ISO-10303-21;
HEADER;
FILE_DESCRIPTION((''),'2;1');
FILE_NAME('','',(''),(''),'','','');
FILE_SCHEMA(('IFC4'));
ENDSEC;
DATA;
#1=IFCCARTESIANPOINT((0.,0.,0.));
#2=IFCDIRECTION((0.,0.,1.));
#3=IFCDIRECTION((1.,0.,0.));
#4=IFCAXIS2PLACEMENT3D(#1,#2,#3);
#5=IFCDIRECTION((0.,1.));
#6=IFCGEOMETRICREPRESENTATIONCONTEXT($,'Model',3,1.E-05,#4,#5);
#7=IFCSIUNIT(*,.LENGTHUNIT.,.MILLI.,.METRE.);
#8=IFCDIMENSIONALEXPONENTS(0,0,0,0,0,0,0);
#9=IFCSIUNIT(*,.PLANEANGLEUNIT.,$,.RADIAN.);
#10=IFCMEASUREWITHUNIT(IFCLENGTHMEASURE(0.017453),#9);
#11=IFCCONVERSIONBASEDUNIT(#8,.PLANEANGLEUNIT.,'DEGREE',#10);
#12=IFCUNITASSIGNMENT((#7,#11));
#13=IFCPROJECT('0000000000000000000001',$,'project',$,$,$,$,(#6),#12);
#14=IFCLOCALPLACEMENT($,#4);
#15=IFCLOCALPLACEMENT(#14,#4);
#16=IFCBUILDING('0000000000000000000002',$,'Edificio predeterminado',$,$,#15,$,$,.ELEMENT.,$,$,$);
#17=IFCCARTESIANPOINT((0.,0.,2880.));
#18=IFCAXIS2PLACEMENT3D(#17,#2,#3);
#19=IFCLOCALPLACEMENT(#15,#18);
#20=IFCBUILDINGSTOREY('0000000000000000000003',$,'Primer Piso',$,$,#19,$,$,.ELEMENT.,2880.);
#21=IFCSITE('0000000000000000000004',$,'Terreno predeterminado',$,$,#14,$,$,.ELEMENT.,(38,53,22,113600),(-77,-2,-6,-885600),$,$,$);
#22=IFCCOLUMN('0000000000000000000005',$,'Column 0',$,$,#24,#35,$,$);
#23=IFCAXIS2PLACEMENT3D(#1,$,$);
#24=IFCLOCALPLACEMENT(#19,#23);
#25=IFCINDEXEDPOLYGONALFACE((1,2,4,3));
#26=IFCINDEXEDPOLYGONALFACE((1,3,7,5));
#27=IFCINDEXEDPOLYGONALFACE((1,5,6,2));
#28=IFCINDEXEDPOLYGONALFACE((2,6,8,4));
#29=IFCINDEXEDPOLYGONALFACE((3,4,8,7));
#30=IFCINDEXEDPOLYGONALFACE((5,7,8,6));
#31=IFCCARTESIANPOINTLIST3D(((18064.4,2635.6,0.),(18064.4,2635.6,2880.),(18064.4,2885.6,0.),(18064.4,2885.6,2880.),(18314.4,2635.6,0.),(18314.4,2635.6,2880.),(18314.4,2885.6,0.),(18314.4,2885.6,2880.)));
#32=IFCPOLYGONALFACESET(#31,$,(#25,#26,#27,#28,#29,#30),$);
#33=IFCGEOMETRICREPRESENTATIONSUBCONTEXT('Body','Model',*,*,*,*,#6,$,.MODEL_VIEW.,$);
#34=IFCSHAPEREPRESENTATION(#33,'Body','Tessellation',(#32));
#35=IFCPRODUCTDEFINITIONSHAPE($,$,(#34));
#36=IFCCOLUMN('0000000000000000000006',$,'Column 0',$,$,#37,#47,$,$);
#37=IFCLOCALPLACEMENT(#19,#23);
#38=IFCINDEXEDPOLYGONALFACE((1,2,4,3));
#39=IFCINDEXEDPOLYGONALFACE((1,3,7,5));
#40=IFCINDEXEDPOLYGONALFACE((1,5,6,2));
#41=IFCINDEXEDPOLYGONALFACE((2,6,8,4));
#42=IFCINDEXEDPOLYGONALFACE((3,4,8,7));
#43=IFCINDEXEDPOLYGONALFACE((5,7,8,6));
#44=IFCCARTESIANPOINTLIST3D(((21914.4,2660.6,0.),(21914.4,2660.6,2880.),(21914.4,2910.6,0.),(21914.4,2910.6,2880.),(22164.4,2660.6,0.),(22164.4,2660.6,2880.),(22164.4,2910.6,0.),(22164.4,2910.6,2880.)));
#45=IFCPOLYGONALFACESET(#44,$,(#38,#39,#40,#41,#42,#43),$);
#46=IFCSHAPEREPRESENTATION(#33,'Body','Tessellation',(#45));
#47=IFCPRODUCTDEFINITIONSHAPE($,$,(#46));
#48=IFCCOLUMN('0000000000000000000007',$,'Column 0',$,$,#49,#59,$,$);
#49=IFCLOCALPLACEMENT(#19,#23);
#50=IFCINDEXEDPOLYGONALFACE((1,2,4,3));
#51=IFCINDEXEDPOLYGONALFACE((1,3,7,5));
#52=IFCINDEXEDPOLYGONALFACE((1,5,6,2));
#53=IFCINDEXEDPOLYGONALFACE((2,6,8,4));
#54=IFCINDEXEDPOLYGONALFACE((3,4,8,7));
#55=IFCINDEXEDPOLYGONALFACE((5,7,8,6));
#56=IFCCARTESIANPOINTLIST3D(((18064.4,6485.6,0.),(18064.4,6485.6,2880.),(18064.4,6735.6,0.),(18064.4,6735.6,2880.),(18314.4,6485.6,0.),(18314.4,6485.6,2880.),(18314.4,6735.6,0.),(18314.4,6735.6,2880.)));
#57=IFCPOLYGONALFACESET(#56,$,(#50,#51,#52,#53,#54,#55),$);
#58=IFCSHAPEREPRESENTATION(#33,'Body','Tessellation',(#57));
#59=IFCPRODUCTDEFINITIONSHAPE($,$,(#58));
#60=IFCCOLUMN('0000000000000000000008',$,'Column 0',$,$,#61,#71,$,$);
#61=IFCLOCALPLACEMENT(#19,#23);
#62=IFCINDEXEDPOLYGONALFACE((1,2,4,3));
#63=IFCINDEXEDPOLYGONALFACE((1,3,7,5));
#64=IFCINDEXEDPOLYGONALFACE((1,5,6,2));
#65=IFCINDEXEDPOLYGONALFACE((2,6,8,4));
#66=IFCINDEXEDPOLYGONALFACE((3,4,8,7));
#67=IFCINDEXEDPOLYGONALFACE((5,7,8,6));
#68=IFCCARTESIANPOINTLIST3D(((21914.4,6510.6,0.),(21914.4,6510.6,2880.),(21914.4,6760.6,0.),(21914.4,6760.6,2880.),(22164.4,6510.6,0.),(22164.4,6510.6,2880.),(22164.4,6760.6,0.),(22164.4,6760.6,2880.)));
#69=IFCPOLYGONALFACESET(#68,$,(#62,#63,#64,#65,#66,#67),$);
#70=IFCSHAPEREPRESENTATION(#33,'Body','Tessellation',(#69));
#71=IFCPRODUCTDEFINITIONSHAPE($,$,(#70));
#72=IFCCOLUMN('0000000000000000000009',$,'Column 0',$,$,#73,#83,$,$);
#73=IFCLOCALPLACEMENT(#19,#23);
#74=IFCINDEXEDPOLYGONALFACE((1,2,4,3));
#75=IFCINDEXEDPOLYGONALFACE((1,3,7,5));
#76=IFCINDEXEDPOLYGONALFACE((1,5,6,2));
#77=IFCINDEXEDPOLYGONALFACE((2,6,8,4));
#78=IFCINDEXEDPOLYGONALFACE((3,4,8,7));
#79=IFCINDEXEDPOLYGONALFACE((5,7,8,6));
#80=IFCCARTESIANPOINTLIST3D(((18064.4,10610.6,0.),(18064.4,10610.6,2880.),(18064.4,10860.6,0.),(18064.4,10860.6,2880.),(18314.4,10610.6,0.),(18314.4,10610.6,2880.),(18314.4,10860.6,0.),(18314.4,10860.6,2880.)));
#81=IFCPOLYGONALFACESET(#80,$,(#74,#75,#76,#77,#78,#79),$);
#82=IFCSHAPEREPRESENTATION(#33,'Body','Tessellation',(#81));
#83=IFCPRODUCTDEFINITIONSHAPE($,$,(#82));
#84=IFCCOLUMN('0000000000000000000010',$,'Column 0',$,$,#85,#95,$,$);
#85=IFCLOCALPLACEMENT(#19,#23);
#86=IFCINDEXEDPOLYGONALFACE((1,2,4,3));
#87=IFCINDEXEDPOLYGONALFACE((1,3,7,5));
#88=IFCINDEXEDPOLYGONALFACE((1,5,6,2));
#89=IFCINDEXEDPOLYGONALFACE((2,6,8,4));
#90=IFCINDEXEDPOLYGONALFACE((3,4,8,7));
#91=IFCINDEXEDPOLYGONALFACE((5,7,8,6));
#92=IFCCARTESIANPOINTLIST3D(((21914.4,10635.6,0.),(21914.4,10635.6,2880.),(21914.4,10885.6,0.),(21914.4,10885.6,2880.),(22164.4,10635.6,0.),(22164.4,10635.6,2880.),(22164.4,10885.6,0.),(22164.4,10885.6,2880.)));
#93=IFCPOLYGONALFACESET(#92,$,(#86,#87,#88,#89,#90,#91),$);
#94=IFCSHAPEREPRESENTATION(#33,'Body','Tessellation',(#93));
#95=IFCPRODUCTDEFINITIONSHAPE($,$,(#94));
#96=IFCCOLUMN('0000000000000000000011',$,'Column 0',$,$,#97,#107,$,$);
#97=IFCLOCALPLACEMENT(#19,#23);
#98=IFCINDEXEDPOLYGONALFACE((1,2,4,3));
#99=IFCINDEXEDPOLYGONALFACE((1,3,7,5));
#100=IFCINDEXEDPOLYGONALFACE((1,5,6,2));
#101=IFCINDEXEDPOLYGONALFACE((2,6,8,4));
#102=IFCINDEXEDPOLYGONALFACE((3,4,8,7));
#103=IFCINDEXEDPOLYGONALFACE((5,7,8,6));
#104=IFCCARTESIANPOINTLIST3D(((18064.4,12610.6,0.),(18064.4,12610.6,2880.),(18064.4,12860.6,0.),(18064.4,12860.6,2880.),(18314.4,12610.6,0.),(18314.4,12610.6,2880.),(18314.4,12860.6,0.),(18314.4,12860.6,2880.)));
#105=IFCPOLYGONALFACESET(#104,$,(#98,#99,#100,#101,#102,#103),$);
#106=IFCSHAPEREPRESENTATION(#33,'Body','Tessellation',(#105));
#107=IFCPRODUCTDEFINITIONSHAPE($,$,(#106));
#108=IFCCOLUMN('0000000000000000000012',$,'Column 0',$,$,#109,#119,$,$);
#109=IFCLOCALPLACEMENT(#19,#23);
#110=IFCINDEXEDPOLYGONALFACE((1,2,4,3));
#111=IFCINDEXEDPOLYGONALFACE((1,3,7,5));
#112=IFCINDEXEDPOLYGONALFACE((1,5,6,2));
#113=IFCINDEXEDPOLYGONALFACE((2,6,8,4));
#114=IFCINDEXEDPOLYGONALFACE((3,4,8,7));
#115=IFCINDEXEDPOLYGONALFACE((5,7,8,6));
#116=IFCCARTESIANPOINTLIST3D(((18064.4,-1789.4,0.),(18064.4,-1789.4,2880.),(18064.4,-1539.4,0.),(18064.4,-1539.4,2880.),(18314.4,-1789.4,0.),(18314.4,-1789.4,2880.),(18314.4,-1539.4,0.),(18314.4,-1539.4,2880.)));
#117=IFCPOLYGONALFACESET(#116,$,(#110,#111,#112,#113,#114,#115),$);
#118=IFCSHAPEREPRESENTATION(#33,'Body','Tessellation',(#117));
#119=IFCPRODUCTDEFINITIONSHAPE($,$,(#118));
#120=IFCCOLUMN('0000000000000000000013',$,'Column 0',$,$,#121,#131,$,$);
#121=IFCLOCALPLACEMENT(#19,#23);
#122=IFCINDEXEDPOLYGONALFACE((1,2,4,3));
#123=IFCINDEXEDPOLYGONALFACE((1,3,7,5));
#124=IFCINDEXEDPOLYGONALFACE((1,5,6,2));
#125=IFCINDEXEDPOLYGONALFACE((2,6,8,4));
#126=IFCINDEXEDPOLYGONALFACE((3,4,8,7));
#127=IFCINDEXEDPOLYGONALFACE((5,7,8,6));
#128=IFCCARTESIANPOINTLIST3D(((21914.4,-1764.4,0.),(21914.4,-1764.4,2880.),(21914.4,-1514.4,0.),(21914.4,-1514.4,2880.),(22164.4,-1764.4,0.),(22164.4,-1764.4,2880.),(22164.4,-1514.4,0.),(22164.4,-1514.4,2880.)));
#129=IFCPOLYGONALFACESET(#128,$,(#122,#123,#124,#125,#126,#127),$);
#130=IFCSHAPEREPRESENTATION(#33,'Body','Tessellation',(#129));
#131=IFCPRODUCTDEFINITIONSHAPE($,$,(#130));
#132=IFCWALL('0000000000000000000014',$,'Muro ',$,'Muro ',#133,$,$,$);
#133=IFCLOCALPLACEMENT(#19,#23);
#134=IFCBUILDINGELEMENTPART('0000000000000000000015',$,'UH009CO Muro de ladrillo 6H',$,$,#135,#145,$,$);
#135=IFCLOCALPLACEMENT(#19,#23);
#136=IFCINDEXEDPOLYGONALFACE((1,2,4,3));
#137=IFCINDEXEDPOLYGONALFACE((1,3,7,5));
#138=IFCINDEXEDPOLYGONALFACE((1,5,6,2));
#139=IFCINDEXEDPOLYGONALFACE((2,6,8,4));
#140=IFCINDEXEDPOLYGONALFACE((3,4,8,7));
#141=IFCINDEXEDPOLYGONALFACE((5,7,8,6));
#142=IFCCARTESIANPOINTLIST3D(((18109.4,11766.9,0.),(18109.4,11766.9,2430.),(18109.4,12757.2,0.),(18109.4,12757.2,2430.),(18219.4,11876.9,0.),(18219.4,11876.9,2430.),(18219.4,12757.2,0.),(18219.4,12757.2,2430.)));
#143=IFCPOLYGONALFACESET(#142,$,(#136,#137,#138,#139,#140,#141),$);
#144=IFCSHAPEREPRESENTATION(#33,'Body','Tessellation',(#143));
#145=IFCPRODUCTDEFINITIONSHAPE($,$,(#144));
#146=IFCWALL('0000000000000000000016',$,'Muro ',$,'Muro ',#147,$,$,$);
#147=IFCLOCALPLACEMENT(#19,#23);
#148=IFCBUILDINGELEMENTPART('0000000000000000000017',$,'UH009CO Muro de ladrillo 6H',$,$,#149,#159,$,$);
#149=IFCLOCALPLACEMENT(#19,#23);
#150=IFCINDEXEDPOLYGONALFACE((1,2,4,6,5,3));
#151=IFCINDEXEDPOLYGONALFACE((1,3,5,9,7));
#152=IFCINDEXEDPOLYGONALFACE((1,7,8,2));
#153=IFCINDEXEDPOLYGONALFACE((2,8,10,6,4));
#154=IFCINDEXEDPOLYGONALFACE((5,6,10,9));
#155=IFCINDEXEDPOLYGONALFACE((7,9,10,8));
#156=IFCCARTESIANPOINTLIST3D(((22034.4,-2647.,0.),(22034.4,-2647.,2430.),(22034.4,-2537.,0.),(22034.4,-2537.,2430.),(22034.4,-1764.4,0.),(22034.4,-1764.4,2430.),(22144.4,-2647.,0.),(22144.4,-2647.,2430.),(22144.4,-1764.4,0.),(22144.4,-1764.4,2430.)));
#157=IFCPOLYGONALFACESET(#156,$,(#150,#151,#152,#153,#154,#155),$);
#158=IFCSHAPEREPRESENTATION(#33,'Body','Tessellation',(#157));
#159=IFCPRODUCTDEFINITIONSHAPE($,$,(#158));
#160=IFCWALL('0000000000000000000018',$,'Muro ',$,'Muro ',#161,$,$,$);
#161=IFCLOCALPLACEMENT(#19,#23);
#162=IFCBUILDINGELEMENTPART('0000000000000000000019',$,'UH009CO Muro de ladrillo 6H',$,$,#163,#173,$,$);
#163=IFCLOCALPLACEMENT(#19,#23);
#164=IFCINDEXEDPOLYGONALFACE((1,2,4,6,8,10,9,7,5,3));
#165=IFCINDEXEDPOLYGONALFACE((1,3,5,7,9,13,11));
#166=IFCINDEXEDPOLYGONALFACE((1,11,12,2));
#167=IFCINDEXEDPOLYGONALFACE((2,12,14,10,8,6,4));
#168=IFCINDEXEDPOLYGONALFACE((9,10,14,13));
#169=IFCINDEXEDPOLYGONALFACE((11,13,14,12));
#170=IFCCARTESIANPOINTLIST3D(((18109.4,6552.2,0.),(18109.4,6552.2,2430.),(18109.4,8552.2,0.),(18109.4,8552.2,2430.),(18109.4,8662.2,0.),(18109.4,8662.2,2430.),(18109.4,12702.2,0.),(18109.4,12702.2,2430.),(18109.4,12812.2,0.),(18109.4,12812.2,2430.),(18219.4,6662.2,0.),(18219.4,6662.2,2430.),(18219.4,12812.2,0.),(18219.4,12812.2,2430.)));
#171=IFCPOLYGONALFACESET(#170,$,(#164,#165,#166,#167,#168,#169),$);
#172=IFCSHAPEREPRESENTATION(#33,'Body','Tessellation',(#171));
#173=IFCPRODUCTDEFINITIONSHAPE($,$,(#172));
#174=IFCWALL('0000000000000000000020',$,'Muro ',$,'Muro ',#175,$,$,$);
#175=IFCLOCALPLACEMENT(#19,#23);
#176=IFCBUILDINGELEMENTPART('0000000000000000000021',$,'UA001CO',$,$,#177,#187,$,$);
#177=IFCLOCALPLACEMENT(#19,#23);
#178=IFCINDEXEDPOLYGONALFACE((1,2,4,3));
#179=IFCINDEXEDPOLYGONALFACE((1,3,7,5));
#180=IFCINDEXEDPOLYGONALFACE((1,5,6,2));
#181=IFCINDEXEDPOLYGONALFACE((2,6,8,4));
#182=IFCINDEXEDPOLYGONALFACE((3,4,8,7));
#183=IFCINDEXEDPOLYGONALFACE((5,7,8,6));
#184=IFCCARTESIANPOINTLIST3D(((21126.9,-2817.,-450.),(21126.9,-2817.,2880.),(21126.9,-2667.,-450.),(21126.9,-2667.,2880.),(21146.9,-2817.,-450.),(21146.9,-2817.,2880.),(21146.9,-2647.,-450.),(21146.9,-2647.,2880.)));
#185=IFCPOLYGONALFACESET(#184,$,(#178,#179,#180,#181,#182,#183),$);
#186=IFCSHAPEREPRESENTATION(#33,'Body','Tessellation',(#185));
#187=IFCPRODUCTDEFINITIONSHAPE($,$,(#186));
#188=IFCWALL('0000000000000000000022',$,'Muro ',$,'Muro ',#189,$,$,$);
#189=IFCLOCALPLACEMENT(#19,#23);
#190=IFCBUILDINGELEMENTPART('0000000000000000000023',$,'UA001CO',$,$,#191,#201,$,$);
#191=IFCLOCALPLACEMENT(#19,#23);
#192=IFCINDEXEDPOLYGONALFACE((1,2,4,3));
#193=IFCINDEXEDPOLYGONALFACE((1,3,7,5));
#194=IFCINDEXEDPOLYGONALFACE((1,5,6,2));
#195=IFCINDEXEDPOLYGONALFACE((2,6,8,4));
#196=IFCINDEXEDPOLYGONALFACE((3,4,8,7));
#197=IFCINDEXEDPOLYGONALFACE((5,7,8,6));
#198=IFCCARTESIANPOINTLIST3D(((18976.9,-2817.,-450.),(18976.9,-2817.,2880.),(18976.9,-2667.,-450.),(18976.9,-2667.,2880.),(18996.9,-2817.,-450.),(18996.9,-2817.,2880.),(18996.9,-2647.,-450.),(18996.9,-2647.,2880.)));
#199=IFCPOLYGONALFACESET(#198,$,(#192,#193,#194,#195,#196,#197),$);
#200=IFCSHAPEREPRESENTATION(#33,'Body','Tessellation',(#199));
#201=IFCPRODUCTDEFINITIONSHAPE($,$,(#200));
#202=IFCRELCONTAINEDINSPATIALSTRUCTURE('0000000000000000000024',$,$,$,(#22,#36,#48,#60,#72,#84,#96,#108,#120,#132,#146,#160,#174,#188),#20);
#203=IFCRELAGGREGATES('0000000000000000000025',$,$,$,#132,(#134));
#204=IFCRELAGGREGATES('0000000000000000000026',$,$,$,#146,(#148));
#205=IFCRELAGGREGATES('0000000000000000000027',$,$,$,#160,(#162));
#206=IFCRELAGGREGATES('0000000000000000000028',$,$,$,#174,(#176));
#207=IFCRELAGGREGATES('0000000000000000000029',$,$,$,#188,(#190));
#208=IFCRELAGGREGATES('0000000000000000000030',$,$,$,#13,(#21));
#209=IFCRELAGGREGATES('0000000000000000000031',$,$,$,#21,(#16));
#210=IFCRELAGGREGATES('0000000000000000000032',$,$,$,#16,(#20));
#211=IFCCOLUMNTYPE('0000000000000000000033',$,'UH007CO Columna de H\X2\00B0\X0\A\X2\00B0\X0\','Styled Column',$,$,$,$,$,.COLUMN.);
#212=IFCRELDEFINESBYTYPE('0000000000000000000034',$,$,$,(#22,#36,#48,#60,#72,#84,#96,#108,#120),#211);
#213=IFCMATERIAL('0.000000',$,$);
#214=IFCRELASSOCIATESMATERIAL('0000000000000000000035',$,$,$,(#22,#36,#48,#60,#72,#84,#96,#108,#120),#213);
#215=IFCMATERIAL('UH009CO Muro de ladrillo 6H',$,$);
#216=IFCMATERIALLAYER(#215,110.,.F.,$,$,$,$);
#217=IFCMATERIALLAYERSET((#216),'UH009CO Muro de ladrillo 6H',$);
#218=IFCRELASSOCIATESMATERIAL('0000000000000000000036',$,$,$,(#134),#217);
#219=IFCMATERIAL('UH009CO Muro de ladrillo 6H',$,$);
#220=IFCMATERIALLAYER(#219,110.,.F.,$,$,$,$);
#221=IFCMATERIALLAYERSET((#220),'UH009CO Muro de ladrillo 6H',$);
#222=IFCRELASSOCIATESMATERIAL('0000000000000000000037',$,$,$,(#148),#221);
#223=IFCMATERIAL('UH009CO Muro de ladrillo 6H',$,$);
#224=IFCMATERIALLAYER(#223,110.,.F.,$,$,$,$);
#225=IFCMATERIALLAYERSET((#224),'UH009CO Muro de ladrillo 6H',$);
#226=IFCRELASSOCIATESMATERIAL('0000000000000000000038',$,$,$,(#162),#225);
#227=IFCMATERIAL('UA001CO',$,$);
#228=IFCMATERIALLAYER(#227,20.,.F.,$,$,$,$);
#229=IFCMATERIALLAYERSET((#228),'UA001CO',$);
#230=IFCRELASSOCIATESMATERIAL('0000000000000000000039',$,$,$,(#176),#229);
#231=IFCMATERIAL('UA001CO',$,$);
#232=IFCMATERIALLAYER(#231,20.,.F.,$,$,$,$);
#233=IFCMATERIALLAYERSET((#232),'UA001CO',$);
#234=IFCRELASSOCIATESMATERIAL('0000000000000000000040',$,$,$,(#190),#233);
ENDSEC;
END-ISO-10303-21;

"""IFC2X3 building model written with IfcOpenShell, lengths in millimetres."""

from ifc_helpers import new_model, entity, si_unit, converted_unit, direction, frame, origin_with_axes, place, context, subcontext, project, spatial, polyline, outline, extrude, clip, bounded_halfspace, material, layer, layer_set, layer_usage, type_object, element, aggregate, save


model = new_model("IFC2X3")

# Units and contexts
model_context = context("Model", 3, precision=1e-05, world=origin_with_axes(), true_north=direction((0.0, 1.0)))
body_context = subcontext(model_context, "Body", "Model", "MODEL_VIEW")
ifc_project = project(units=[si_unit("LENGTHUNIT", "METRE", prefix="MILLI"), converted_unit("PLANEANGLEUNIT", "DEGREE", entity("IfcLengthMeasure", 0.017453), si_unit("PLANEANGLEUNIT", "RADIAN"), dimensions=[0, 0, 0, 0, 0, 0, 0])], contexts=[model_context])

# Site, building, storey
site_placement = place(None, origin_with_axes())
site = spatial("IfcSite", under=ifc_project, at=site_placement, Name="Terreno predeterminado", CompositionType="ELEMENT", RefLatitude=(38, 53, 22, 113600), RefLongitude=(-77, -2, -6, -885600))
building_placement = place(site_placement, origin_with_axes())
building = spatial("IfcBuilding", under=site, at=building_placement, Name="Edificio predeterminado", CompositionType="ELEMENT")
storey_placement = place(building_placement, frame((0.0, 0.0, 2880.0), z_axis=(0.0, 0.0, 1.0), x_axis=(1.0, 0.0, 0.0)))
storey = spatial("IfcBuildingStorey", under=building, at=storey_placement, Name="Primer Piso", CompositionType="ELEMENT", Elevation=2880.0)

# Columns
ifc_material_1 = material(Name="0.000000")
column_type = type_object("IfcColumnType", Name="UH007CO Columna de H°A°", Description="Styled Column", PredefinedType="COLUMN")
for number, where, z_axis, x_axis, name in (
    (1, (18189.4, 2760.6, 0.0), (0.0, 0.0, 1.0), (1.0, 0.0, 0.0), "Column 0"),
    (2, (22039.4, 2785.6, 0.0), (0.0, 0.0, 1.0), (1.0, 0.0, 0.0), "Column 0"),
    (3, (18189.4, 6610.6, 0.0), (0.0, 0.0, 1.0), (1.0, 0.0, 0.0), "Column 0"),
    (4, (22039.4, 6635.6, 0.0), (0.0, 0.0, 1.0), (1.0, 0.0, 0.0), "Column 0"),
    (5, (18189.4, 10735.6, 0.0), (0.0, 0.0, 1.0), (1.0, 0.0, 0.0), "Column 0"),
    (6, (22039.4, 10760.6, 0.0), (0.0, 0.0, 1.0), (1.0, 0.0, 0.0), "Column 0"),
    (7, (18189.4, 12735.6, 0.0), (0.0, 0.0, 1.0), (1.0, 0.0, 0.0), "Column 0"),
    (8, (18189.4, -1664.4, 0.0), (0.0, 0.0, 1.0), (1.0, 0.0, 0.0), "Column 0"),
    (9, (22039.4, -1639.4, 0.0), (0.0, 0.0, 1.0), (1.0, 0.0, 0.0), "Column 0"),
):
    element("IfcColumn", number, at=place(storey_placement, frame(where, z_axis=z_axis, x_axis=x_axis)), inside=storey, type_object=column_type, material=ifc_material_1, Name=name, context=body_context, shape_type="SweptSolid", body=[
        extrude(outline(polyline([(-125.0, -125.0), (125.0, -125.0), (125.0, 125.0), (-125.0, 125.0), (-125.0, -125.0)])), origin_with_axes(), (0.0, 0.0, 1.0), 2880.0),
    ])

# Walls, building element parts
wall_1_placement = place(storey_placement, frame((18164.4, 11821.9, 0.0), z_axis=(0.0, 0.0, 1.0), x_axis=(0.0, 1.0, 0.0)))
wall_1 = element("IfcWall", 10, at=wall_1_placement, inside=storey, Name="Muro ", ObjectType="Muro ")
ifc_material_2 = material(Name="UH009CO Muro de ladrillo 6H")
ifc_layer_1 = layer(ifc_material_2, 110.0, ventilated=False)
ifc_layer_set_1 = layer_set([ifc_layer_1], Name="UH009CO Muro de ladrillo 6H")
ifc_layer_usage_1 = layer_usage(ifc_layer_set_1, "AXIS2", "NEGATIVE", -55.0)
building_element_part_1_placement = place(wall_1_placement, origin_with_axes())
building_element_part_1 = element("IfcBuildingElementPart", 11, at=building_element_part_1_placement, material=ifc_layer_usage_1, Name="UH009CO Muro de ladrillo 6H", context=body_context, shape_type="SweptSolid", body=[
    extrude(outline(polyline([(935.2, 55.0), (935.2, -55.0), (55.0, -55.0), (-55.0, 55.0), (935.2, 55.0)])), origin_with_axes(), (0.0, 0.0, 1.0), 2430.0),
])
aggregate(wall_1, [building_element_part_1])
wall_2_placement = place(storey_placement, frame((22089.4, -1764.4, 0.0), z_axis=(0.0, 0.0, 1.0), x_axis=(0.0, -1.0, 0.0)))
wall_2 = element("IfcWall", 12, at=wall_2_placement, inside=storey, Name="Muro ", ObjectType="Muro ")
ifc_material_3 = material(Name="UH009CO Muro de ladrillo 6H")
ifc_layer_2 = layer(ifc_material_3, 110.0, ventilated=False)
ifc_layer_set_2 = layer_set([ifc_layer_2], Name="UH009CO Muro de ladrillo 6H")
ifc_layer_usage_2 = layer_usage(ifc_layer_set_2, "AXIS2", "NEGATIVE", -55.0)
building_element_part_2_placement = place(wall_2_placement, origin_with_axes())
building_element_part_2 = element("IfcBuildingElementPart", 13, at=building_element_part_2_placement, material=ifc_layer_usage_2, Name="UH009CO Muro de ladrillo 6H", context=body_context, shape_type="SweptSolid", body=[
    extrude(outline(polyline([(882.6, 55.0), (882.6, -55.0), (772.6, -55.0), (0.0, -55.0), (0.0, 55.0), (882.6, 55.0)])), origin_with_axes(), (0.0, 0.0, 1.0), 2430.0),
])
aggregate(wall_2, [building_element_part_2])
wall_3_placement = place(storey_placement, frame((18164.4, 12757.2, 0.0), z_axis=(0.0, 0.0, 1.0), x_axis=(0.0, -1.0, 0.0)))
wall_3 = element("IfcWall", 14, at=wall_3_placement, inside=storey, Name="Muro ", ObjectType="Muro ")
ifc_material_4 = material(Name="UH009CO Muro de ladrillo 6H")
ifc_layer_3 = layer(ifc_material_4, 110.0, ventilated=False)
ifc_layer_set_3 = layer_set([ifc_layer_3], Name="UH009CO Muro de ladrillo 6H")
ifc_layer_usage_3 = layer_usage(ifc_layer_set_3, "AXIS2", "NEGATIVE", -55.0)
building_element_part_3_placement = place(wall_3_placement, origin_with_axes())
building_element_part_3 = element("IfcBuildingElementPart", 15, at=building_element_part_3_placement, material=ifc_layer_usage_3, Name="UH009CO Muro de ladrillo 6H", context=body_context, shape_type="SweptSolid", body=[
    extrude(outline(polyline([(6095.0, 55.0), (6205.0, -55.0), (4205.0, -55.0), (4095.0, -55.0), (55.0, -55.0), (-55.0, -55.0), (-55.0, 55.0), (6095.0, 55.0)])), origin_with_axes(), (0.0, 0.0, 1.0), 2430.0),
])
aggregate(wall_3, [building_element_part_3])
wall_4_placement = place(storey_placement, frame((21201.9, -2817.0, 0.0), z_axis=(0.0, 0.0, 1.0), x_axis=(0.0, 1.0, 0.0)))
wall_4 = element("IfcWall", 16, at=wall_4_placement, inside=storey, Name="Muro ", ObjectType="Muro ")
ifc_material_5 = material(Name="UA001CO")
ifc_layer_4 = layer(ifc_material_5, 20.0, ventilated=False)
ifc_layer_set_4 = layer_set([ifc_layer_4], Name="UA001CO")
ifc_layer_usage_4 = layer_usage(ifc_layer_set_4, "AXIS2", "NEGATIVE", -75.0)
building_element_part_4_placement = place(wall_4_placement, origin_with_axes())
building_element_part_4 = element("IfcBuildingElementPart", 17, at=building_element_part_4_placement, material=ifc_layer_usage_4, Name="UA001CO", context=body_context, shape_type="Clipping", body=[
    clip(clip(extrude(outline(polyline([(150.0, 75.0), (170.0, 55.0), (0.0, 55.0), (0.0, 75.0), (150.0, 75.0)])), frame((0.0, 0.0, -450.0), z_axis=(0.0, 0.0, 1.0), x_axis=(1.0, 0.0, 0.0)), (0.0, 0.0, 1.0), 3330.0), bounded_halfspace(frame((0.0, 0.0, -450.0), z_axis=(0.0, 0.0, 1.0), x_axis=(1.0, 0.0, 0.0)), True, origin_with_axes(), polyline([(-150.0, -150.0), (375.0, -150.0), (375.0, 150.0), (-150.0, 150.0), (-150.0, -150.0)]))), bounded_halfspace(frame((0.0, 0.0, 2880.0), z_axis=(0.0, 0.0, 1.0), x_axis=(1.0, 0.0, 0.0)), False, origin_with_axes(), polyline([(-150.0, -150.0), (375.0, -150.0), (375.0, 150.0), (-150.0, 150.0), (-150.0, -150.0)]))),
])
aggregate(wall_4, [building_element_part_4])
wall_5_placement = place(storey_placement, frame((19051.9, -2817.0, 0.0), z_axis=(0.0, 0.0, 1.0), x_axis=(0.0, 1.0, 0.0)))
wall_5 = element("IfcWall", 18, at=wall_5_placement, inside=storey, Name="Muro ", ObjectType="Muro ")
ifc_material_6 = material(Name="UA001CO")
ifc_layer_5 = layer(ifc_material_6, 20.0, ventilated=False)
ifc_layer_set_5 = layer_set([ifc_layer_5], Name="UA001CO")
ifc_layer_usage_5 = layer_usage(ifc_layer_set_5, "AXIS2", "NEGATIVE", -75.0)
building_element_part_5_placement = place(wall_5_placement, origin_with_axes())
building_element_part_5 = element("IfcBuildingElementPart", 19, at=building_element_part_5_placement, material=ifc_layer_usage_5, Name="UA001CO", context=body_context, shape_type="Clipping", body=[
    clip(clip(extrude(outline(polyline([(150.0, 75.0), (170.0, 55.0), (0.0, 55.0), (0.0, 75.0), (150.0, 75.0)])), frame((0.0, 0.0, -450.0), z_axis=(0.0, 0.0, 1.0), x_axis=(1.0, 0.0, 0.0)), (0.0, 0.0, 1.0), 3330.0), bounded_halfspace(frame((0.0, 0.0, -450.0), z_axis=(0.0, 0.0, 1.0), x_axis=(1.0, 0.0, 0.0)), True, origin_with_axes(), polyline([(-150.0, -150.0), (375.0, -150.0), (375.0, 150.0), (-150.0, 150.0), (-150.0, -150.0)]))), bounded_halfspace(frame((0.0, 0.0, 2880.0), z_axis=(0.0, 0.0, 1.0), x_axis=(1.0, 0.0, 0.0)), False, origin_with_axes(), polyline([(-150.0, -150.0), (375.0, -150.0), (375.0, 150.0), (-150.0, 150.0), (-150.0, -150.0)]))),
])
aggregate(wall_5, [building_element_part_5])

save(model, "model.ifc")
